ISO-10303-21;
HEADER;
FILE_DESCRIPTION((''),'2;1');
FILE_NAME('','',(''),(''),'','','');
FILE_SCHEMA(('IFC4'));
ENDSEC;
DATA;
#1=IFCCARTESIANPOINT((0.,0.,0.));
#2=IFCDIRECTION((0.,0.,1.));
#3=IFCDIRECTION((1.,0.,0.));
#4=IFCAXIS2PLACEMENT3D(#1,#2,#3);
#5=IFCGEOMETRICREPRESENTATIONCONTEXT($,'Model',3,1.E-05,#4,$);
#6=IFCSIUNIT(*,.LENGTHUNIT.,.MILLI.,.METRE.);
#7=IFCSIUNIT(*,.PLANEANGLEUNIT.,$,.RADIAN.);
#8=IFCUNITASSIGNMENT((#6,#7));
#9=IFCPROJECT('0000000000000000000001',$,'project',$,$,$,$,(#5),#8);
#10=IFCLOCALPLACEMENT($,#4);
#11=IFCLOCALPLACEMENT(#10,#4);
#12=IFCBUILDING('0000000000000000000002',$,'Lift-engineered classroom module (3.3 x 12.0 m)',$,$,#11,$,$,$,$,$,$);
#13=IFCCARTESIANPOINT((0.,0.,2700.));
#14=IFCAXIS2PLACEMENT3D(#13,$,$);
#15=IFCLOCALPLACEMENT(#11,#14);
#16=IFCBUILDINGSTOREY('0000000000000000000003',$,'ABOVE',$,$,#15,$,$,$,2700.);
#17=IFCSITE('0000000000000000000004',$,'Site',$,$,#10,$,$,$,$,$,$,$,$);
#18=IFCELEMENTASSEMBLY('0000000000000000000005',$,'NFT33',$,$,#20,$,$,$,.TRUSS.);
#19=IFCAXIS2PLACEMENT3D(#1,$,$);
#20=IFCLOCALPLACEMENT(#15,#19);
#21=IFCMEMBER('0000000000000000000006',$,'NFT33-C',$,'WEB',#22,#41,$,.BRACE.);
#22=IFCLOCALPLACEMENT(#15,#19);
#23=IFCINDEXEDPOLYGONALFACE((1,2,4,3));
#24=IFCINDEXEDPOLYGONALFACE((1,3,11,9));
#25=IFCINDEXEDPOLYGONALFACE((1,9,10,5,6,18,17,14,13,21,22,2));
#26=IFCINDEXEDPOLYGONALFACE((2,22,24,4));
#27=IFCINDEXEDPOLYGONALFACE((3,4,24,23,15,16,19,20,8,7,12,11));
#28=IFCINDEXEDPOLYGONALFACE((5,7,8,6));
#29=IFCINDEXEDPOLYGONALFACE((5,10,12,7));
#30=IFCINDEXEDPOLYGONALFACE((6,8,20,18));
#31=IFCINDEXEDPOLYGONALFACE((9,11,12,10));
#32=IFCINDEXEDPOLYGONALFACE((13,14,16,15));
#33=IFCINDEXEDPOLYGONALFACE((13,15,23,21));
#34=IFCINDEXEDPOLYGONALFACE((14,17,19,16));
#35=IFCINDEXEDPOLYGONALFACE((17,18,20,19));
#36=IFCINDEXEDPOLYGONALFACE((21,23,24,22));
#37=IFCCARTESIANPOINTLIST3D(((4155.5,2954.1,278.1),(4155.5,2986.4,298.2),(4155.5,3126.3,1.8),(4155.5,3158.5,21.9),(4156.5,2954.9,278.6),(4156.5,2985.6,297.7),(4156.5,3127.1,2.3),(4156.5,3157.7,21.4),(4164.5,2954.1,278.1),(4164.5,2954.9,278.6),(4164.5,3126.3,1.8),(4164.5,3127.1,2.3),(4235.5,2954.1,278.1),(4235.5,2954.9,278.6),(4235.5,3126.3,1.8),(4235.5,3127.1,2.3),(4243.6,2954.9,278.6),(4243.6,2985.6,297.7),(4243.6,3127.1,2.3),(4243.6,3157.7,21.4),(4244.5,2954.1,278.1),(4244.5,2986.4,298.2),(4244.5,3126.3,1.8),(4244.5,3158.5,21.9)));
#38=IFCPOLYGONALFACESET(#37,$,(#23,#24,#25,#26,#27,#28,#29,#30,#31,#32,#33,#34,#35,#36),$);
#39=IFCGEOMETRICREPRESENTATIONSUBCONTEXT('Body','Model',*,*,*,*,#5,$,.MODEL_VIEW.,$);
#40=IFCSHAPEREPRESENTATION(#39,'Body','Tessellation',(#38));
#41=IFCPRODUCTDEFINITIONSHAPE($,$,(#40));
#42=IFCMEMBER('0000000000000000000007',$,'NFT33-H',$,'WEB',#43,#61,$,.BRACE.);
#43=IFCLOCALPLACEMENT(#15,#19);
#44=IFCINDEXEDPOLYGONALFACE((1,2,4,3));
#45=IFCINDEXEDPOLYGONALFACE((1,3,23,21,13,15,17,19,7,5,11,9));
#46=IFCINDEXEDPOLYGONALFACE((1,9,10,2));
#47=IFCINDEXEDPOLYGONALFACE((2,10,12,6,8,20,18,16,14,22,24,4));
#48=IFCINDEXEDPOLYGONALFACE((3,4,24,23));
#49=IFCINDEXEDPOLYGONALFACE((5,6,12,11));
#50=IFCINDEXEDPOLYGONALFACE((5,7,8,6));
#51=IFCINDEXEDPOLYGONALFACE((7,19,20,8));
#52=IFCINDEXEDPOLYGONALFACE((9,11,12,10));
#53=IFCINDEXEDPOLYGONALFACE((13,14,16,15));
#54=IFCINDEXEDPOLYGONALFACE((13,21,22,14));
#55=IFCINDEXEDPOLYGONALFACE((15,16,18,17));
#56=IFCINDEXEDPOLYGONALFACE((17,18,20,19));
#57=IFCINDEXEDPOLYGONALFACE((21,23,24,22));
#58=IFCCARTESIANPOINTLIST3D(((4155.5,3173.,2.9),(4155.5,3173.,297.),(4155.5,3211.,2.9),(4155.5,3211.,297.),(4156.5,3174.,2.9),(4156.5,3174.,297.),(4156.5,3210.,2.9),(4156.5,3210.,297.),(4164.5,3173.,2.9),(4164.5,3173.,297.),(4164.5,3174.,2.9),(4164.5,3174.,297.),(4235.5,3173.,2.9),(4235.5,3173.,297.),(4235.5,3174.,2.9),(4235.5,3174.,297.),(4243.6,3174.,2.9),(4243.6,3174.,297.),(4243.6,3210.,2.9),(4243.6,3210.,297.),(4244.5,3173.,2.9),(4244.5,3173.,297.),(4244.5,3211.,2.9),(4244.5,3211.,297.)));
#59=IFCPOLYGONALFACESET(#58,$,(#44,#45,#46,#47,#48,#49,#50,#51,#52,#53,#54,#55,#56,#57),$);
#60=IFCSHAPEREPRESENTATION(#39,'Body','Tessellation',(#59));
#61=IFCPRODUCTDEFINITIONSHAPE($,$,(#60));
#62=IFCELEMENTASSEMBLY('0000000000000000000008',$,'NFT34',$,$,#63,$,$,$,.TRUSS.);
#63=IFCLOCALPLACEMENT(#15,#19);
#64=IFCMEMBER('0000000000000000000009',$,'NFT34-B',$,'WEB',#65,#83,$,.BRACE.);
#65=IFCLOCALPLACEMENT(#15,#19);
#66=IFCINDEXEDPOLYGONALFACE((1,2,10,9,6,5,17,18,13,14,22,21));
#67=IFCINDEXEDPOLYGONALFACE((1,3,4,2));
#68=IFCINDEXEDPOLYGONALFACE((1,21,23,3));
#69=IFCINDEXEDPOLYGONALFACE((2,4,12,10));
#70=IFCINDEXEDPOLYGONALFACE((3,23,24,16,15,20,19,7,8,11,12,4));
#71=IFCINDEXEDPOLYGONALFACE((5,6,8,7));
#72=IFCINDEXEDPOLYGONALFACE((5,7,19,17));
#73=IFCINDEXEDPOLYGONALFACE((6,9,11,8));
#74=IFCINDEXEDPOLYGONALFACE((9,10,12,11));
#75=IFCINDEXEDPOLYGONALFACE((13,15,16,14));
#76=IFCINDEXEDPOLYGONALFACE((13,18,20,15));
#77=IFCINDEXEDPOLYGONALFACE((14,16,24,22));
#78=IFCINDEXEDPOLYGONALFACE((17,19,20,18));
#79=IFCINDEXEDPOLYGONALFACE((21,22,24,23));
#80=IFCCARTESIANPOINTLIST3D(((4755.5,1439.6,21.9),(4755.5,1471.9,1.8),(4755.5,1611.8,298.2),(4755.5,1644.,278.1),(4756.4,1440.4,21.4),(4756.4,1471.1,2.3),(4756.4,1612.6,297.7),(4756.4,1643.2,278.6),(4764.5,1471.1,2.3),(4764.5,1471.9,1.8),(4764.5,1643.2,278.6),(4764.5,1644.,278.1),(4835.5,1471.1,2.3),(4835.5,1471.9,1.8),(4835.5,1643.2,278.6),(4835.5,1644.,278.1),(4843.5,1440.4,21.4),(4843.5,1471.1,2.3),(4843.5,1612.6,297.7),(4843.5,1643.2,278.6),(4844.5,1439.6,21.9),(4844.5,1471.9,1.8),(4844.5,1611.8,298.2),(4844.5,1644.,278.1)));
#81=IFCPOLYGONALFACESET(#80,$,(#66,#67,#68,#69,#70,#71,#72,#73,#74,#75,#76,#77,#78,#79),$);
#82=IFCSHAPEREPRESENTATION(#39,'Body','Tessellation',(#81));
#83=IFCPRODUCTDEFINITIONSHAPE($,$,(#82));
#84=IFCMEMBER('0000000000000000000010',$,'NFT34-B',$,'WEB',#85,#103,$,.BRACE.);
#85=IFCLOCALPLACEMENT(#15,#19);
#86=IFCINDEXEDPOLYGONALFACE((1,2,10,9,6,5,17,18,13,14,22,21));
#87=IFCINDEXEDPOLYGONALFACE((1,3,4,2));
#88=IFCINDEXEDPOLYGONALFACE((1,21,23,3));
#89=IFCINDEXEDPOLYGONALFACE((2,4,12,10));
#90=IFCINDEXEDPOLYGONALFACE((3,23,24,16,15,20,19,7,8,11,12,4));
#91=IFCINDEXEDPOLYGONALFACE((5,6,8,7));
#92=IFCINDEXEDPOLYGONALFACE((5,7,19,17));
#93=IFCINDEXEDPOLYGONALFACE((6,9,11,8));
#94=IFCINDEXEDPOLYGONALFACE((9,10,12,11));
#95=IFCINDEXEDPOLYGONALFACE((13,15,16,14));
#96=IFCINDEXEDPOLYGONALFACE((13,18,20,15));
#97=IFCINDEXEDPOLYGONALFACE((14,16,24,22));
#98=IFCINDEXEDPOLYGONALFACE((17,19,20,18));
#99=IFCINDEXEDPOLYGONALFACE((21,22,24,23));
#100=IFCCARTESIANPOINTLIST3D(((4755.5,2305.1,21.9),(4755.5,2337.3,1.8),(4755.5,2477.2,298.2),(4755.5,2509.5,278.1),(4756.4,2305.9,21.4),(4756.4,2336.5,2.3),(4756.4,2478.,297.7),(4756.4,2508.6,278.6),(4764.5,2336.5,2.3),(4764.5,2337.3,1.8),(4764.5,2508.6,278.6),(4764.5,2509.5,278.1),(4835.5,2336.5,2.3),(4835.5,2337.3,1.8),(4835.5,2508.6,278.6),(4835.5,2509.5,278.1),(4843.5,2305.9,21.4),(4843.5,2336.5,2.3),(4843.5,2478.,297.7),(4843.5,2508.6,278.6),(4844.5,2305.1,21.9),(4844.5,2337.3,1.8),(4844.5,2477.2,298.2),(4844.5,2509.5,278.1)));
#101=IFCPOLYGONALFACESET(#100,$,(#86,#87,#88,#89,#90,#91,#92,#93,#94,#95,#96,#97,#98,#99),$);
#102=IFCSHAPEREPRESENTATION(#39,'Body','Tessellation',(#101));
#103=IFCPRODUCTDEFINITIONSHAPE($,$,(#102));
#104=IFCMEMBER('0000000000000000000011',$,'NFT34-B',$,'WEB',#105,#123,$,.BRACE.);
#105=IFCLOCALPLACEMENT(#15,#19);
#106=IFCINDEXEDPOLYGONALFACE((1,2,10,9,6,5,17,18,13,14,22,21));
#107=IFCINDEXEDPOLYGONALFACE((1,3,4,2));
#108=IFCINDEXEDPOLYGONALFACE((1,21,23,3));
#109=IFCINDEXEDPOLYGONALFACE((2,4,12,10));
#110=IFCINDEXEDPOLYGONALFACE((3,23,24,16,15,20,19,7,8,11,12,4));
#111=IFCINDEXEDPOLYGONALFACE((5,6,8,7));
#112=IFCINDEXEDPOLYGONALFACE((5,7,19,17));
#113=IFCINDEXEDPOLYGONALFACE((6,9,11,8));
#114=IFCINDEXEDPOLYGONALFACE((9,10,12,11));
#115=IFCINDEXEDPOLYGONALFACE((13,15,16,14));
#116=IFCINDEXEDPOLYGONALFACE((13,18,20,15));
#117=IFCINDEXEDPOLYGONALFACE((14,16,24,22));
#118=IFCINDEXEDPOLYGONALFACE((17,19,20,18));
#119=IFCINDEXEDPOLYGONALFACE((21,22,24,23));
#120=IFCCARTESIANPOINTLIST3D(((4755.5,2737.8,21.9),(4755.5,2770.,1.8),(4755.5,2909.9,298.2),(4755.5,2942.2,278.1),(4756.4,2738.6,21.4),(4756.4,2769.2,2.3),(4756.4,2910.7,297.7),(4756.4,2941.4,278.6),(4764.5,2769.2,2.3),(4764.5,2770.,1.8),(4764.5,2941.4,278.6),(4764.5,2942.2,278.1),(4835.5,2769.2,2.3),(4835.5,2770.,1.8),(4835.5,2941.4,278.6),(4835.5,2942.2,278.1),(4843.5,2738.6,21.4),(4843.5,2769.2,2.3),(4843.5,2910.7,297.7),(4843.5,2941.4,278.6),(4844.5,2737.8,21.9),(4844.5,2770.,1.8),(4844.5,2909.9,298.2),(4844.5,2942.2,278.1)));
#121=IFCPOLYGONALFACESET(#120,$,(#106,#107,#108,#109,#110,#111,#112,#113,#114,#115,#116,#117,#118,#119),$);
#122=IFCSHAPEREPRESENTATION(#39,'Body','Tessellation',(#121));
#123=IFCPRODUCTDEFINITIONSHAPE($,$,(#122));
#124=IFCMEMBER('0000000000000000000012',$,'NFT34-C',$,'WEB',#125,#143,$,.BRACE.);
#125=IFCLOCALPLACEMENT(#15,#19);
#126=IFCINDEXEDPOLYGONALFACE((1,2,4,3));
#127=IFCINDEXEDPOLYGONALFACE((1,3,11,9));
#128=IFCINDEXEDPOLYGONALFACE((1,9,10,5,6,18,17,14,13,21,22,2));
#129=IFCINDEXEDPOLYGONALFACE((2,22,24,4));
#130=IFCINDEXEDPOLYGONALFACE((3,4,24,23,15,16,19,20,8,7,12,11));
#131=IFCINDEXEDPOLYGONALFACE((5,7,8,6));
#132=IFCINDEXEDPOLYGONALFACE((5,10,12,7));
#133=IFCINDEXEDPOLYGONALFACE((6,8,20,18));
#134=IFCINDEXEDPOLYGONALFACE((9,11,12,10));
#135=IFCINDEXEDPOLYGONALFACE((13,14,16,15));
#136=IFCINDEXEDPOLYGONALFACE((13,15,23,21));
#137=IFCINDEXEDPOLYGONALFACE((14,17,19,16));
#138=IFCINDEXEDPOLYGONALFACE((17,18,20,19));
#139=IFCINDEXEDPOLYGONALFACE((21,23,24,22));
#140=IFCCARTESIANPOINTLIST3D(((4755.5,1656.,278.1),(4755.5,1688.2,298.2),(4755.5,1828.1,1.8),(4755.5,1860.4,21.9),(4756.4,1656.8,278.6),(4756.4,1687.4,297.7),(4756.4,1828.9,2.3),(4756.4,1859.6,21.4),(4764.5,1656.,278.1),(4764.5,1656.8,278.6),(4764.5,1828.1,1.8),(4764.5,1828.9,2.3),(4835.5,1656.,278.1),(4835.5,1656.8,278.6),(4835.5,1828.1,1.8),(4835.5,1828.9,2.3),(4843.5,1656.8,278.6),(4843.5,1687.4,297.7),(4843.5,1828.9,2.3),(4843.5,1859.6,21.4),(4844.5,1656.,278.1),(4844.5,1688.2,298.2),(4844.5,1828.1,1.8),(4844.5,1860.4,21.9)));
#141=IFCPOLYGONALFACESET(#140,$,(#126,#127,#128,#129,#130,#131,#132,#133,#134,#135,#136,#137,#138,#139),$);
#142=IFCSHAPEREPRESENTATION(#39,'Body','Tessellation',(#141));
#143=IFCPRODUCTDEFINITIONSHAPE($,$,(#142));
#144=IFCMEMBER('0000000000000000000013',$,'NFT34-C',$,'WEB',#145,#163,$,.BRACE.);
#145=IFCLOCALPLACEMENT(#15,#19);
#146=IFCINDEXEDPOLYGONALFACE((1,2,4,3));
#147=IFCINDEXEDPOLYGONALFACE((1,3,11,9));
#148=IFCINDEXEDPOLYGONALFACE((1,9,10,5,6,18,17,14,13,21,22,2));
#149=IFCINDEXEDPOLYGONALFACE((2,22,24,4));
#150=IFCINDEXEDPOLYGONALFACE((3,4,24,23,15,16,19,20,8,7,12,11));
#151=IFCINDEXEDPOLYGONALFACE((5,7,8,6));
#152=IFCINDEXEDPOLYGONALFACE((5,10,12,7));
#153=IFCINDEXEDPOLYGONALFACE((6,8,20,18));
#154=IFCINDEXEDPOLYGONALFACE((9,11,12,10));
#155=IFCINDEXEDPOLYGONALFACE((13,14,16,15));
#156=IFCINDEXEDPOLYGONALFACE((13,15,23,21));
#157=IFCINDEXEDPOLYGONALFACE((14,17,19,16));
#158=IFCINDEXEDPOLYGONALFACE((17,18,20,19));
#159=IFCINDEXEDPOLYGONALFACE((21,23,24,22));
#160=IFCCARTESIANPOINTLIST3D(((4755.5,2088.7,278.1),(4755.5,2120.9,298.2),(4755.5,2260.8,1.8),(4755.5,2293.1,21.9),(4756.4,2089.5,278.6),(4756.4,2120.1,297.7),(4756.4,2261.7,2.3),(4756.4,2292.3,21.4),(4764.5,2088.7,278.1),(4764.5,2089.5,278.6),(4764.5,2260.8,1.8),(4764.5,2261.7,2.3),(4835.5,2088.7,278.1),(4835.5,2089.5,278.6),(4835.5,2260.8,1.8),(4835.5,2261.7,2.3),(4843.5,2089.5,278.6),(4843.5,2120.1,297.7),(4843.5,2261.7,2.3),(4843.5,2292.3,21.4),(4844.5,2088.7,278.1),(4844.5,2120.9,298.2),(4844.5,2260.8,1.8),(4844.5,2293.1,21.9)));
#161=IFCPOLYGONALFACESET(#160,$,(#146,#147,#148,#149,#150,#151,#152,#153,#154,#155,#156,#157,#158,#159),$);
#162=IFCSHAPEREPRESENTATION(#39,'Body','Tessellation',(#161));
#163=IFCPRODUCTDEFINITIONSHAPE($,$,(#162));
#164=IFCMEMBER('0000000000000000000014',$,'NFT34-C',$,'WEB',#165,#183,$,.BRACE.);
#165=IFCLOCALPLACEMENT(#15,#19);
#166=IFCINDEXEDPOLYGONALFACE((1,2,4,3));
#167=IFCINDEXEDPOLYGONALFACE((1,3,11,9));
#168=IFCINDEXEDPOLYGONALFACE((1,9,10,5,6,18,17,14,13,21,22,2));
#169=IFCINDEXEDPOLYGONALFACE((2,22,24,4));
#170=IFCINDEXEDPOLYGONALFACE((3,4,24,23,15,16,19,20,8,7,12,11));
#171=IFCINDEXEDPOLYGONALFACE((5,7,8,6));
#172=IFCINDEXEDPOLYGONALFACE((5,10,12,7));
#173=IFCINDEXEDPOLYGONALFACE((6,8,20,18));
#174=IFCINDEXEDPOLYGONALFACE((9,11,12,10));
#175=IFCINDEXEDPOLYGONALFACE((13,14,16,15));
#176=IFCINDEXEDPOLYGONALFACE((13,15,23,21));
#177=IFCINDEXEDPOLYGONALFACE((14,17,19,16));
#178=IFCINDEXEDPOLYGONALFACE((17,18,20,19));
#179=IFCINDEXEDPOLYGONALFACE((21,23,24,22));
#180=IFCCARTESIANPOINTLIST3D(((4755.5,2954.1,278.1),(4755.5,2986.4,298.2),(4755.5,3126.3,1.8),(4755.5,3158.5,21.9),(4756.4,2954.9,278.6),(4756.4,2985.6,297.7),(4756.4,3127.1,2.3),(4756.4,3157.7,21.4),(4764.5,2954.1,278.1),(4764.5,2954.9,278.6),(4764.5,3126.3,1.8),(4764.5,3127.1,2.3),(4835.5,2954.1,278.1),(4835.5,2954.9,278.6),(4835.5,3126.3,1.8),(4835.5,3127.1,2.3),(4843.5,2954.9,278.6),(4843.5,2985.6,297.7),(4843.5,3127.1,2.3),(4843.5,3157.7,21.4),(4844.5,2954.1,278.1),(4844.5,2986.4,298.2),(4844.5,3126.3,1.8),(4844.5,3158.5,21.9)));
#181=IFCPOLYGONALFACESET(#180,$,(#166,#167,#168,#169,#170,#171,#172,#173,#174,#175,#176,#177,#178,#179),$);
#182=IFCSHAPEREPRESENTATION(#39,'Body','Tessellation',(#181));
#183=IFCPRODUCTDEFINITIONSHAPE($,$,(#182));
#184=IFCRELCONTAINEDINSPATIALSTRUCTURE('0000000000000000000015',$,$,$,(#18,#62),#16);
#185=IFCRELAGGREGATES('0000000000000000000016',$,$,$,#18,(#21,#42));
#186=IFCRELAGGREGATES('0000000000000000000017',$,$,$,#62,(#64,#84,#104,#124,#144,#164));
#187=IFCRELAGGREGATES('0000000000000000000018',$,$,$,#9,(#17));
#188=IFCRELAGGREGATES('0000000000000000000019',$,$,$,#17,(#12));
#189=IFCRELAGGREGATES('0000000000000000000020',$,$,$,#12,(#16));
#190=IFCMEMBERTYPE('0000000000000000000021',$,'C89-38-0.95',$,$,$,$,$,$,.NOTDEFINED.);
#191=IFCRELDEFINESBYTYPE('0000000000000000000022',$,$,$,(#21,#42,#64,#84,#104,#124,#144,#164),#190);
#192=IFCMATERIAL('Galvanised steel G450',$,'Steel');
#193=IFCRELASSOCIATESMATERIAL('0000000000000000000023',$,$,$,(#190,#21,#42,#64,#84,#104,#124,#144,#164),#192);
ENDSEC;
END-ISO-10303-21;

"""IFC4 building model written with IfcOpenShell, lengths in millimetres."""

from ifc_helpers import new_model, si_unit, frame, origin, origin_with_axes, origin_2d, place, context, subcontext, project, spatial, c_section, extrude, material, material_profile, profile_set, profile_usage, type_object, element, aggregate, save


model = new_model("IFC4")

# Units and contexts
model_context = context("Model", 3, precision=1e-05, world=origin_with_axes())
body_context = subcontext(model_context, "Body", "Model", "MODEL_VIEW")
ifc_project = project(units=[si_unit("LENGTHUNIT", "METRE", prefix="MILLI"), si_unit("PLANEANGLEUNIT", "RADIAN")], contexts=[model_context])

# Site, building, storey
site_placement = place(None, origin_with_axes())
site = spatial("IfcSite", under=ifc_project, at=site_placement, Name="Site")
building_placement = place(site_placement, origin_with_axes())
building = spatial("IfcBuilding", under=site, at=building_placement, Name="Lift-engineered classroom module (3.3 x 12.0 m)")
storey_placement = place(building_placement, frame((0.0, 0.0, 2700.0)))
storey = spatial("IfcBuildingStorey", under=building, at=storey_placement, Name="ABOVE", Elevation=2700.0)

# Element assemblies, members
assembly_1_placement = place(storey_placement, frame((4200.0, 89.0, 0.0)))
assembly_1 = element("IfcElementAssembly", 1, at=assembly_1_placement, inside=storey, Name="NFT33", PredefinedType="TRUSS")
ifc_material = material(Name="Galvanised steel G450", Category="Steel")
ifc_material_profile_1 = material_profile(ifc_material, c_section(Depth=89.0, Width=38.0, WallThickness=0.9, Girth=9.0, at=origin_2d()), Name="C89-38-0.95")
ifc_profile_set_1 = profile_set([ifc_material_profile_1], Name="C89-38-0.95")
ifc_profile_usage_1 = profile_usage(ifc_profile_set_1)
member_type_1 = type_object("IfcMemberType", Name="C89-38-0.95", PredefinedType="NOTDEFINED", material=ifc_profile_set_1)
member_1_placement = place(assembly_1_placement, frame((0.0, 3053.4, 11.8), z_axis=(0.0, -0.528797, 0.848748), x_axis=(0.0, -0.848748, -0.528797)))
member_1 = element("IfcMember", 2, at=member_1_placement, type_object=member_type_1, material=ifc_profile_usage_1, Name="NFT33-C", ObjectType="WEB", PredefinedType="BRACE", context=body_context, shape_type="SweptSolid", body=[
    extrude(c_section(Depth=89.0, Width=38.0, WallThickness=0.9, Girth=9.0, at=origin_2d()), origin(), (0.0, 0.0, 1.0), 325.6),
])
member_2_placement = place(assembly_1_placement, frame((0.0, 3103.0, 2.9), z_axis=(0.0, 0.0, 1.0), x_axis=(0.0, -1.0, 0.0)))
member_2 = element("IfcMember", 3, at=member_2_placement, type_object=member_type_1, material=ifc_profile_usage_1, Name="NFT33-H", ObjectType="WEB", PredefinedType="BRACE", context=body_context, shape_type="SweptSolid", body=[
    extrude(c_section(Depth=89.0, Width=38.0, WallThickness=0.9, Girth=9.0, at=origin_2d()), origin(), (0.0, 0.0, 1.0), 294.1),
])
aggregate(assembly_1, [member_1, member_2])
assembly_2_placement = place(storey_placement, frame((4800.0, 89.0, 0.0)))
assembly_2 = element("IfcElementAssembly", 4, at=assembly_2_placement, inside=storey, Name="NFT34", PredefinedType="TRUSS")
member_3_placement = place(assembly_2_placement, frame((0.0, 1366.7, 11.8), z_axis=(0.0, 0.528797, 0.848748), x_axis=(0.0, 0.848748, -0.528797)))
member_3 = element("IfcMember", 5, at=member_3_placement, type_object=member_type_1, material=ifc_profile_usage_1, Name="NFT34-B", ObjectType="WEB", PredefinedType="BRACE", context=body_context, shape_type="SweptSolid", body=[
    extrude(c_section(Depth=89.0, Width=38.0, WallThickness=0.9, Girth=9.0, at=origin_2d()), origin(), (0.0, 0.0, 1.0), 325.6),
])
member_4_placement = place(assembly_2_placement, frame((0.0, 2232.2, 11.8), z_axis=(0.0, 0.528797, 0.848748), x_axis=(0.0, 0.848748, -0.528797)))
member_4 = element("IfcMember", 6, at=member_4_placement, type_object=member_type_1, material=ifc_profile_usage_1, Name="NFT34-B", ObjectType="WEB", PredefinedType="BRACE", context=body_context, shape_type="SweptSolid", body=[
    extrude(c_section(Depth=89.0, Width=38.0, WallThickness=0.9, Girth=9.0, at=origin_2d()), origin(), (0.0, 0.0, 1.0), 325.6),
])
member_5_placement = place(assembly_2_placement, frame((0.0, 2664.9, 11.8), z_axis=(0.0, 0.528797, 0.848748), x_axis=(0.0, 0.848748, -0.528797)))
member_5 = element("IfcMember", 7, at=member_5_placement, type_object=member_type_1, material=ifc_profile_usage_1, Name="NFT34-B", ObjectType="WEB", PredefinedType="BRACE", context=body_context, shape_type="SweptSolid", body=[
    extrude(c_section(Depth=89.0, Width=38.0, WallThickness=0.9, Girth=9.0, at=origin_2d()), origin(), (0.0, 0.0, 1.0), 325.6),
])
member_6_placement = place(assembly_2_placement, frame((0.0, 1755.3, 11.8), z_axis=(0.0, -0.528797, 0.848748), x_axis=(0.0, -0.848748, -0.528797)))
member_6 = element("IfcMember", 8, at=member_6_placement, type_object=member_type_1, material=ifc_profile_usage_1, Name="NFT34-C", ObjectType="WEB", PredefinedType="BRACE", context=body_context, shape_type="SweptSolid", body=[
    extrude(c_section(Depth=89.0, Width=38.0, WallThickness=0.9, Girth=9.0, at=origin_2d()), origin(), (0.0, 0.0, 1.0), 325.6),
])
member_7_placement = place(assembly_2_placement, frame((0.0, 2188.0, 11.8), z_axis=(0.0, -0.528797, 0.848748), x_axis=(0.0, -0.848748, -0.528797)))
member_7 = element("IfcMember", 9, at=member_7_placement, type_object=member_type_1, material=ifc_profile_usage_1, Name="NFT34-C", ObjectType="WEB", PredefinedType="BRACE", context=body_context, shape_type="SweptSolid", body=[
    extrude(c_section(Depth=89.0, Width=38.0, WallThickness=0.9, Girth=9.0, at=origin_2d()), origin(), (0.0, 0.0, 1.0), 325.6),
])
member_8_placement = place(assembly_2_placement, frame((0.0, 3053.4, 11.8), z_axis=(0.0, -0.528797, 0.848748), x_axis=(0.0, -0.848748, -0.528797)))
member_8 = element("IfcMember", 10, at=member_8_placement, type_object=member_type_1, material=ifc_profile_usage_1, Name="NFT34-C", ObjectType="WEB", PredefinedType="BRACE", context=body_context, shape_type="SweptSolid", body=[
    extrude(c_section(Depth=89.0, Width=38.0, WallThickness=0.9, Girth=9.0, at=origin_2d()), origin(), (0.0, 0.0, 1.0), 325.6),
])
aggregate(assembly_2, [member_3, member_4, member_5, member_6, member_7, member_8])

save(model, "model.ifc")
